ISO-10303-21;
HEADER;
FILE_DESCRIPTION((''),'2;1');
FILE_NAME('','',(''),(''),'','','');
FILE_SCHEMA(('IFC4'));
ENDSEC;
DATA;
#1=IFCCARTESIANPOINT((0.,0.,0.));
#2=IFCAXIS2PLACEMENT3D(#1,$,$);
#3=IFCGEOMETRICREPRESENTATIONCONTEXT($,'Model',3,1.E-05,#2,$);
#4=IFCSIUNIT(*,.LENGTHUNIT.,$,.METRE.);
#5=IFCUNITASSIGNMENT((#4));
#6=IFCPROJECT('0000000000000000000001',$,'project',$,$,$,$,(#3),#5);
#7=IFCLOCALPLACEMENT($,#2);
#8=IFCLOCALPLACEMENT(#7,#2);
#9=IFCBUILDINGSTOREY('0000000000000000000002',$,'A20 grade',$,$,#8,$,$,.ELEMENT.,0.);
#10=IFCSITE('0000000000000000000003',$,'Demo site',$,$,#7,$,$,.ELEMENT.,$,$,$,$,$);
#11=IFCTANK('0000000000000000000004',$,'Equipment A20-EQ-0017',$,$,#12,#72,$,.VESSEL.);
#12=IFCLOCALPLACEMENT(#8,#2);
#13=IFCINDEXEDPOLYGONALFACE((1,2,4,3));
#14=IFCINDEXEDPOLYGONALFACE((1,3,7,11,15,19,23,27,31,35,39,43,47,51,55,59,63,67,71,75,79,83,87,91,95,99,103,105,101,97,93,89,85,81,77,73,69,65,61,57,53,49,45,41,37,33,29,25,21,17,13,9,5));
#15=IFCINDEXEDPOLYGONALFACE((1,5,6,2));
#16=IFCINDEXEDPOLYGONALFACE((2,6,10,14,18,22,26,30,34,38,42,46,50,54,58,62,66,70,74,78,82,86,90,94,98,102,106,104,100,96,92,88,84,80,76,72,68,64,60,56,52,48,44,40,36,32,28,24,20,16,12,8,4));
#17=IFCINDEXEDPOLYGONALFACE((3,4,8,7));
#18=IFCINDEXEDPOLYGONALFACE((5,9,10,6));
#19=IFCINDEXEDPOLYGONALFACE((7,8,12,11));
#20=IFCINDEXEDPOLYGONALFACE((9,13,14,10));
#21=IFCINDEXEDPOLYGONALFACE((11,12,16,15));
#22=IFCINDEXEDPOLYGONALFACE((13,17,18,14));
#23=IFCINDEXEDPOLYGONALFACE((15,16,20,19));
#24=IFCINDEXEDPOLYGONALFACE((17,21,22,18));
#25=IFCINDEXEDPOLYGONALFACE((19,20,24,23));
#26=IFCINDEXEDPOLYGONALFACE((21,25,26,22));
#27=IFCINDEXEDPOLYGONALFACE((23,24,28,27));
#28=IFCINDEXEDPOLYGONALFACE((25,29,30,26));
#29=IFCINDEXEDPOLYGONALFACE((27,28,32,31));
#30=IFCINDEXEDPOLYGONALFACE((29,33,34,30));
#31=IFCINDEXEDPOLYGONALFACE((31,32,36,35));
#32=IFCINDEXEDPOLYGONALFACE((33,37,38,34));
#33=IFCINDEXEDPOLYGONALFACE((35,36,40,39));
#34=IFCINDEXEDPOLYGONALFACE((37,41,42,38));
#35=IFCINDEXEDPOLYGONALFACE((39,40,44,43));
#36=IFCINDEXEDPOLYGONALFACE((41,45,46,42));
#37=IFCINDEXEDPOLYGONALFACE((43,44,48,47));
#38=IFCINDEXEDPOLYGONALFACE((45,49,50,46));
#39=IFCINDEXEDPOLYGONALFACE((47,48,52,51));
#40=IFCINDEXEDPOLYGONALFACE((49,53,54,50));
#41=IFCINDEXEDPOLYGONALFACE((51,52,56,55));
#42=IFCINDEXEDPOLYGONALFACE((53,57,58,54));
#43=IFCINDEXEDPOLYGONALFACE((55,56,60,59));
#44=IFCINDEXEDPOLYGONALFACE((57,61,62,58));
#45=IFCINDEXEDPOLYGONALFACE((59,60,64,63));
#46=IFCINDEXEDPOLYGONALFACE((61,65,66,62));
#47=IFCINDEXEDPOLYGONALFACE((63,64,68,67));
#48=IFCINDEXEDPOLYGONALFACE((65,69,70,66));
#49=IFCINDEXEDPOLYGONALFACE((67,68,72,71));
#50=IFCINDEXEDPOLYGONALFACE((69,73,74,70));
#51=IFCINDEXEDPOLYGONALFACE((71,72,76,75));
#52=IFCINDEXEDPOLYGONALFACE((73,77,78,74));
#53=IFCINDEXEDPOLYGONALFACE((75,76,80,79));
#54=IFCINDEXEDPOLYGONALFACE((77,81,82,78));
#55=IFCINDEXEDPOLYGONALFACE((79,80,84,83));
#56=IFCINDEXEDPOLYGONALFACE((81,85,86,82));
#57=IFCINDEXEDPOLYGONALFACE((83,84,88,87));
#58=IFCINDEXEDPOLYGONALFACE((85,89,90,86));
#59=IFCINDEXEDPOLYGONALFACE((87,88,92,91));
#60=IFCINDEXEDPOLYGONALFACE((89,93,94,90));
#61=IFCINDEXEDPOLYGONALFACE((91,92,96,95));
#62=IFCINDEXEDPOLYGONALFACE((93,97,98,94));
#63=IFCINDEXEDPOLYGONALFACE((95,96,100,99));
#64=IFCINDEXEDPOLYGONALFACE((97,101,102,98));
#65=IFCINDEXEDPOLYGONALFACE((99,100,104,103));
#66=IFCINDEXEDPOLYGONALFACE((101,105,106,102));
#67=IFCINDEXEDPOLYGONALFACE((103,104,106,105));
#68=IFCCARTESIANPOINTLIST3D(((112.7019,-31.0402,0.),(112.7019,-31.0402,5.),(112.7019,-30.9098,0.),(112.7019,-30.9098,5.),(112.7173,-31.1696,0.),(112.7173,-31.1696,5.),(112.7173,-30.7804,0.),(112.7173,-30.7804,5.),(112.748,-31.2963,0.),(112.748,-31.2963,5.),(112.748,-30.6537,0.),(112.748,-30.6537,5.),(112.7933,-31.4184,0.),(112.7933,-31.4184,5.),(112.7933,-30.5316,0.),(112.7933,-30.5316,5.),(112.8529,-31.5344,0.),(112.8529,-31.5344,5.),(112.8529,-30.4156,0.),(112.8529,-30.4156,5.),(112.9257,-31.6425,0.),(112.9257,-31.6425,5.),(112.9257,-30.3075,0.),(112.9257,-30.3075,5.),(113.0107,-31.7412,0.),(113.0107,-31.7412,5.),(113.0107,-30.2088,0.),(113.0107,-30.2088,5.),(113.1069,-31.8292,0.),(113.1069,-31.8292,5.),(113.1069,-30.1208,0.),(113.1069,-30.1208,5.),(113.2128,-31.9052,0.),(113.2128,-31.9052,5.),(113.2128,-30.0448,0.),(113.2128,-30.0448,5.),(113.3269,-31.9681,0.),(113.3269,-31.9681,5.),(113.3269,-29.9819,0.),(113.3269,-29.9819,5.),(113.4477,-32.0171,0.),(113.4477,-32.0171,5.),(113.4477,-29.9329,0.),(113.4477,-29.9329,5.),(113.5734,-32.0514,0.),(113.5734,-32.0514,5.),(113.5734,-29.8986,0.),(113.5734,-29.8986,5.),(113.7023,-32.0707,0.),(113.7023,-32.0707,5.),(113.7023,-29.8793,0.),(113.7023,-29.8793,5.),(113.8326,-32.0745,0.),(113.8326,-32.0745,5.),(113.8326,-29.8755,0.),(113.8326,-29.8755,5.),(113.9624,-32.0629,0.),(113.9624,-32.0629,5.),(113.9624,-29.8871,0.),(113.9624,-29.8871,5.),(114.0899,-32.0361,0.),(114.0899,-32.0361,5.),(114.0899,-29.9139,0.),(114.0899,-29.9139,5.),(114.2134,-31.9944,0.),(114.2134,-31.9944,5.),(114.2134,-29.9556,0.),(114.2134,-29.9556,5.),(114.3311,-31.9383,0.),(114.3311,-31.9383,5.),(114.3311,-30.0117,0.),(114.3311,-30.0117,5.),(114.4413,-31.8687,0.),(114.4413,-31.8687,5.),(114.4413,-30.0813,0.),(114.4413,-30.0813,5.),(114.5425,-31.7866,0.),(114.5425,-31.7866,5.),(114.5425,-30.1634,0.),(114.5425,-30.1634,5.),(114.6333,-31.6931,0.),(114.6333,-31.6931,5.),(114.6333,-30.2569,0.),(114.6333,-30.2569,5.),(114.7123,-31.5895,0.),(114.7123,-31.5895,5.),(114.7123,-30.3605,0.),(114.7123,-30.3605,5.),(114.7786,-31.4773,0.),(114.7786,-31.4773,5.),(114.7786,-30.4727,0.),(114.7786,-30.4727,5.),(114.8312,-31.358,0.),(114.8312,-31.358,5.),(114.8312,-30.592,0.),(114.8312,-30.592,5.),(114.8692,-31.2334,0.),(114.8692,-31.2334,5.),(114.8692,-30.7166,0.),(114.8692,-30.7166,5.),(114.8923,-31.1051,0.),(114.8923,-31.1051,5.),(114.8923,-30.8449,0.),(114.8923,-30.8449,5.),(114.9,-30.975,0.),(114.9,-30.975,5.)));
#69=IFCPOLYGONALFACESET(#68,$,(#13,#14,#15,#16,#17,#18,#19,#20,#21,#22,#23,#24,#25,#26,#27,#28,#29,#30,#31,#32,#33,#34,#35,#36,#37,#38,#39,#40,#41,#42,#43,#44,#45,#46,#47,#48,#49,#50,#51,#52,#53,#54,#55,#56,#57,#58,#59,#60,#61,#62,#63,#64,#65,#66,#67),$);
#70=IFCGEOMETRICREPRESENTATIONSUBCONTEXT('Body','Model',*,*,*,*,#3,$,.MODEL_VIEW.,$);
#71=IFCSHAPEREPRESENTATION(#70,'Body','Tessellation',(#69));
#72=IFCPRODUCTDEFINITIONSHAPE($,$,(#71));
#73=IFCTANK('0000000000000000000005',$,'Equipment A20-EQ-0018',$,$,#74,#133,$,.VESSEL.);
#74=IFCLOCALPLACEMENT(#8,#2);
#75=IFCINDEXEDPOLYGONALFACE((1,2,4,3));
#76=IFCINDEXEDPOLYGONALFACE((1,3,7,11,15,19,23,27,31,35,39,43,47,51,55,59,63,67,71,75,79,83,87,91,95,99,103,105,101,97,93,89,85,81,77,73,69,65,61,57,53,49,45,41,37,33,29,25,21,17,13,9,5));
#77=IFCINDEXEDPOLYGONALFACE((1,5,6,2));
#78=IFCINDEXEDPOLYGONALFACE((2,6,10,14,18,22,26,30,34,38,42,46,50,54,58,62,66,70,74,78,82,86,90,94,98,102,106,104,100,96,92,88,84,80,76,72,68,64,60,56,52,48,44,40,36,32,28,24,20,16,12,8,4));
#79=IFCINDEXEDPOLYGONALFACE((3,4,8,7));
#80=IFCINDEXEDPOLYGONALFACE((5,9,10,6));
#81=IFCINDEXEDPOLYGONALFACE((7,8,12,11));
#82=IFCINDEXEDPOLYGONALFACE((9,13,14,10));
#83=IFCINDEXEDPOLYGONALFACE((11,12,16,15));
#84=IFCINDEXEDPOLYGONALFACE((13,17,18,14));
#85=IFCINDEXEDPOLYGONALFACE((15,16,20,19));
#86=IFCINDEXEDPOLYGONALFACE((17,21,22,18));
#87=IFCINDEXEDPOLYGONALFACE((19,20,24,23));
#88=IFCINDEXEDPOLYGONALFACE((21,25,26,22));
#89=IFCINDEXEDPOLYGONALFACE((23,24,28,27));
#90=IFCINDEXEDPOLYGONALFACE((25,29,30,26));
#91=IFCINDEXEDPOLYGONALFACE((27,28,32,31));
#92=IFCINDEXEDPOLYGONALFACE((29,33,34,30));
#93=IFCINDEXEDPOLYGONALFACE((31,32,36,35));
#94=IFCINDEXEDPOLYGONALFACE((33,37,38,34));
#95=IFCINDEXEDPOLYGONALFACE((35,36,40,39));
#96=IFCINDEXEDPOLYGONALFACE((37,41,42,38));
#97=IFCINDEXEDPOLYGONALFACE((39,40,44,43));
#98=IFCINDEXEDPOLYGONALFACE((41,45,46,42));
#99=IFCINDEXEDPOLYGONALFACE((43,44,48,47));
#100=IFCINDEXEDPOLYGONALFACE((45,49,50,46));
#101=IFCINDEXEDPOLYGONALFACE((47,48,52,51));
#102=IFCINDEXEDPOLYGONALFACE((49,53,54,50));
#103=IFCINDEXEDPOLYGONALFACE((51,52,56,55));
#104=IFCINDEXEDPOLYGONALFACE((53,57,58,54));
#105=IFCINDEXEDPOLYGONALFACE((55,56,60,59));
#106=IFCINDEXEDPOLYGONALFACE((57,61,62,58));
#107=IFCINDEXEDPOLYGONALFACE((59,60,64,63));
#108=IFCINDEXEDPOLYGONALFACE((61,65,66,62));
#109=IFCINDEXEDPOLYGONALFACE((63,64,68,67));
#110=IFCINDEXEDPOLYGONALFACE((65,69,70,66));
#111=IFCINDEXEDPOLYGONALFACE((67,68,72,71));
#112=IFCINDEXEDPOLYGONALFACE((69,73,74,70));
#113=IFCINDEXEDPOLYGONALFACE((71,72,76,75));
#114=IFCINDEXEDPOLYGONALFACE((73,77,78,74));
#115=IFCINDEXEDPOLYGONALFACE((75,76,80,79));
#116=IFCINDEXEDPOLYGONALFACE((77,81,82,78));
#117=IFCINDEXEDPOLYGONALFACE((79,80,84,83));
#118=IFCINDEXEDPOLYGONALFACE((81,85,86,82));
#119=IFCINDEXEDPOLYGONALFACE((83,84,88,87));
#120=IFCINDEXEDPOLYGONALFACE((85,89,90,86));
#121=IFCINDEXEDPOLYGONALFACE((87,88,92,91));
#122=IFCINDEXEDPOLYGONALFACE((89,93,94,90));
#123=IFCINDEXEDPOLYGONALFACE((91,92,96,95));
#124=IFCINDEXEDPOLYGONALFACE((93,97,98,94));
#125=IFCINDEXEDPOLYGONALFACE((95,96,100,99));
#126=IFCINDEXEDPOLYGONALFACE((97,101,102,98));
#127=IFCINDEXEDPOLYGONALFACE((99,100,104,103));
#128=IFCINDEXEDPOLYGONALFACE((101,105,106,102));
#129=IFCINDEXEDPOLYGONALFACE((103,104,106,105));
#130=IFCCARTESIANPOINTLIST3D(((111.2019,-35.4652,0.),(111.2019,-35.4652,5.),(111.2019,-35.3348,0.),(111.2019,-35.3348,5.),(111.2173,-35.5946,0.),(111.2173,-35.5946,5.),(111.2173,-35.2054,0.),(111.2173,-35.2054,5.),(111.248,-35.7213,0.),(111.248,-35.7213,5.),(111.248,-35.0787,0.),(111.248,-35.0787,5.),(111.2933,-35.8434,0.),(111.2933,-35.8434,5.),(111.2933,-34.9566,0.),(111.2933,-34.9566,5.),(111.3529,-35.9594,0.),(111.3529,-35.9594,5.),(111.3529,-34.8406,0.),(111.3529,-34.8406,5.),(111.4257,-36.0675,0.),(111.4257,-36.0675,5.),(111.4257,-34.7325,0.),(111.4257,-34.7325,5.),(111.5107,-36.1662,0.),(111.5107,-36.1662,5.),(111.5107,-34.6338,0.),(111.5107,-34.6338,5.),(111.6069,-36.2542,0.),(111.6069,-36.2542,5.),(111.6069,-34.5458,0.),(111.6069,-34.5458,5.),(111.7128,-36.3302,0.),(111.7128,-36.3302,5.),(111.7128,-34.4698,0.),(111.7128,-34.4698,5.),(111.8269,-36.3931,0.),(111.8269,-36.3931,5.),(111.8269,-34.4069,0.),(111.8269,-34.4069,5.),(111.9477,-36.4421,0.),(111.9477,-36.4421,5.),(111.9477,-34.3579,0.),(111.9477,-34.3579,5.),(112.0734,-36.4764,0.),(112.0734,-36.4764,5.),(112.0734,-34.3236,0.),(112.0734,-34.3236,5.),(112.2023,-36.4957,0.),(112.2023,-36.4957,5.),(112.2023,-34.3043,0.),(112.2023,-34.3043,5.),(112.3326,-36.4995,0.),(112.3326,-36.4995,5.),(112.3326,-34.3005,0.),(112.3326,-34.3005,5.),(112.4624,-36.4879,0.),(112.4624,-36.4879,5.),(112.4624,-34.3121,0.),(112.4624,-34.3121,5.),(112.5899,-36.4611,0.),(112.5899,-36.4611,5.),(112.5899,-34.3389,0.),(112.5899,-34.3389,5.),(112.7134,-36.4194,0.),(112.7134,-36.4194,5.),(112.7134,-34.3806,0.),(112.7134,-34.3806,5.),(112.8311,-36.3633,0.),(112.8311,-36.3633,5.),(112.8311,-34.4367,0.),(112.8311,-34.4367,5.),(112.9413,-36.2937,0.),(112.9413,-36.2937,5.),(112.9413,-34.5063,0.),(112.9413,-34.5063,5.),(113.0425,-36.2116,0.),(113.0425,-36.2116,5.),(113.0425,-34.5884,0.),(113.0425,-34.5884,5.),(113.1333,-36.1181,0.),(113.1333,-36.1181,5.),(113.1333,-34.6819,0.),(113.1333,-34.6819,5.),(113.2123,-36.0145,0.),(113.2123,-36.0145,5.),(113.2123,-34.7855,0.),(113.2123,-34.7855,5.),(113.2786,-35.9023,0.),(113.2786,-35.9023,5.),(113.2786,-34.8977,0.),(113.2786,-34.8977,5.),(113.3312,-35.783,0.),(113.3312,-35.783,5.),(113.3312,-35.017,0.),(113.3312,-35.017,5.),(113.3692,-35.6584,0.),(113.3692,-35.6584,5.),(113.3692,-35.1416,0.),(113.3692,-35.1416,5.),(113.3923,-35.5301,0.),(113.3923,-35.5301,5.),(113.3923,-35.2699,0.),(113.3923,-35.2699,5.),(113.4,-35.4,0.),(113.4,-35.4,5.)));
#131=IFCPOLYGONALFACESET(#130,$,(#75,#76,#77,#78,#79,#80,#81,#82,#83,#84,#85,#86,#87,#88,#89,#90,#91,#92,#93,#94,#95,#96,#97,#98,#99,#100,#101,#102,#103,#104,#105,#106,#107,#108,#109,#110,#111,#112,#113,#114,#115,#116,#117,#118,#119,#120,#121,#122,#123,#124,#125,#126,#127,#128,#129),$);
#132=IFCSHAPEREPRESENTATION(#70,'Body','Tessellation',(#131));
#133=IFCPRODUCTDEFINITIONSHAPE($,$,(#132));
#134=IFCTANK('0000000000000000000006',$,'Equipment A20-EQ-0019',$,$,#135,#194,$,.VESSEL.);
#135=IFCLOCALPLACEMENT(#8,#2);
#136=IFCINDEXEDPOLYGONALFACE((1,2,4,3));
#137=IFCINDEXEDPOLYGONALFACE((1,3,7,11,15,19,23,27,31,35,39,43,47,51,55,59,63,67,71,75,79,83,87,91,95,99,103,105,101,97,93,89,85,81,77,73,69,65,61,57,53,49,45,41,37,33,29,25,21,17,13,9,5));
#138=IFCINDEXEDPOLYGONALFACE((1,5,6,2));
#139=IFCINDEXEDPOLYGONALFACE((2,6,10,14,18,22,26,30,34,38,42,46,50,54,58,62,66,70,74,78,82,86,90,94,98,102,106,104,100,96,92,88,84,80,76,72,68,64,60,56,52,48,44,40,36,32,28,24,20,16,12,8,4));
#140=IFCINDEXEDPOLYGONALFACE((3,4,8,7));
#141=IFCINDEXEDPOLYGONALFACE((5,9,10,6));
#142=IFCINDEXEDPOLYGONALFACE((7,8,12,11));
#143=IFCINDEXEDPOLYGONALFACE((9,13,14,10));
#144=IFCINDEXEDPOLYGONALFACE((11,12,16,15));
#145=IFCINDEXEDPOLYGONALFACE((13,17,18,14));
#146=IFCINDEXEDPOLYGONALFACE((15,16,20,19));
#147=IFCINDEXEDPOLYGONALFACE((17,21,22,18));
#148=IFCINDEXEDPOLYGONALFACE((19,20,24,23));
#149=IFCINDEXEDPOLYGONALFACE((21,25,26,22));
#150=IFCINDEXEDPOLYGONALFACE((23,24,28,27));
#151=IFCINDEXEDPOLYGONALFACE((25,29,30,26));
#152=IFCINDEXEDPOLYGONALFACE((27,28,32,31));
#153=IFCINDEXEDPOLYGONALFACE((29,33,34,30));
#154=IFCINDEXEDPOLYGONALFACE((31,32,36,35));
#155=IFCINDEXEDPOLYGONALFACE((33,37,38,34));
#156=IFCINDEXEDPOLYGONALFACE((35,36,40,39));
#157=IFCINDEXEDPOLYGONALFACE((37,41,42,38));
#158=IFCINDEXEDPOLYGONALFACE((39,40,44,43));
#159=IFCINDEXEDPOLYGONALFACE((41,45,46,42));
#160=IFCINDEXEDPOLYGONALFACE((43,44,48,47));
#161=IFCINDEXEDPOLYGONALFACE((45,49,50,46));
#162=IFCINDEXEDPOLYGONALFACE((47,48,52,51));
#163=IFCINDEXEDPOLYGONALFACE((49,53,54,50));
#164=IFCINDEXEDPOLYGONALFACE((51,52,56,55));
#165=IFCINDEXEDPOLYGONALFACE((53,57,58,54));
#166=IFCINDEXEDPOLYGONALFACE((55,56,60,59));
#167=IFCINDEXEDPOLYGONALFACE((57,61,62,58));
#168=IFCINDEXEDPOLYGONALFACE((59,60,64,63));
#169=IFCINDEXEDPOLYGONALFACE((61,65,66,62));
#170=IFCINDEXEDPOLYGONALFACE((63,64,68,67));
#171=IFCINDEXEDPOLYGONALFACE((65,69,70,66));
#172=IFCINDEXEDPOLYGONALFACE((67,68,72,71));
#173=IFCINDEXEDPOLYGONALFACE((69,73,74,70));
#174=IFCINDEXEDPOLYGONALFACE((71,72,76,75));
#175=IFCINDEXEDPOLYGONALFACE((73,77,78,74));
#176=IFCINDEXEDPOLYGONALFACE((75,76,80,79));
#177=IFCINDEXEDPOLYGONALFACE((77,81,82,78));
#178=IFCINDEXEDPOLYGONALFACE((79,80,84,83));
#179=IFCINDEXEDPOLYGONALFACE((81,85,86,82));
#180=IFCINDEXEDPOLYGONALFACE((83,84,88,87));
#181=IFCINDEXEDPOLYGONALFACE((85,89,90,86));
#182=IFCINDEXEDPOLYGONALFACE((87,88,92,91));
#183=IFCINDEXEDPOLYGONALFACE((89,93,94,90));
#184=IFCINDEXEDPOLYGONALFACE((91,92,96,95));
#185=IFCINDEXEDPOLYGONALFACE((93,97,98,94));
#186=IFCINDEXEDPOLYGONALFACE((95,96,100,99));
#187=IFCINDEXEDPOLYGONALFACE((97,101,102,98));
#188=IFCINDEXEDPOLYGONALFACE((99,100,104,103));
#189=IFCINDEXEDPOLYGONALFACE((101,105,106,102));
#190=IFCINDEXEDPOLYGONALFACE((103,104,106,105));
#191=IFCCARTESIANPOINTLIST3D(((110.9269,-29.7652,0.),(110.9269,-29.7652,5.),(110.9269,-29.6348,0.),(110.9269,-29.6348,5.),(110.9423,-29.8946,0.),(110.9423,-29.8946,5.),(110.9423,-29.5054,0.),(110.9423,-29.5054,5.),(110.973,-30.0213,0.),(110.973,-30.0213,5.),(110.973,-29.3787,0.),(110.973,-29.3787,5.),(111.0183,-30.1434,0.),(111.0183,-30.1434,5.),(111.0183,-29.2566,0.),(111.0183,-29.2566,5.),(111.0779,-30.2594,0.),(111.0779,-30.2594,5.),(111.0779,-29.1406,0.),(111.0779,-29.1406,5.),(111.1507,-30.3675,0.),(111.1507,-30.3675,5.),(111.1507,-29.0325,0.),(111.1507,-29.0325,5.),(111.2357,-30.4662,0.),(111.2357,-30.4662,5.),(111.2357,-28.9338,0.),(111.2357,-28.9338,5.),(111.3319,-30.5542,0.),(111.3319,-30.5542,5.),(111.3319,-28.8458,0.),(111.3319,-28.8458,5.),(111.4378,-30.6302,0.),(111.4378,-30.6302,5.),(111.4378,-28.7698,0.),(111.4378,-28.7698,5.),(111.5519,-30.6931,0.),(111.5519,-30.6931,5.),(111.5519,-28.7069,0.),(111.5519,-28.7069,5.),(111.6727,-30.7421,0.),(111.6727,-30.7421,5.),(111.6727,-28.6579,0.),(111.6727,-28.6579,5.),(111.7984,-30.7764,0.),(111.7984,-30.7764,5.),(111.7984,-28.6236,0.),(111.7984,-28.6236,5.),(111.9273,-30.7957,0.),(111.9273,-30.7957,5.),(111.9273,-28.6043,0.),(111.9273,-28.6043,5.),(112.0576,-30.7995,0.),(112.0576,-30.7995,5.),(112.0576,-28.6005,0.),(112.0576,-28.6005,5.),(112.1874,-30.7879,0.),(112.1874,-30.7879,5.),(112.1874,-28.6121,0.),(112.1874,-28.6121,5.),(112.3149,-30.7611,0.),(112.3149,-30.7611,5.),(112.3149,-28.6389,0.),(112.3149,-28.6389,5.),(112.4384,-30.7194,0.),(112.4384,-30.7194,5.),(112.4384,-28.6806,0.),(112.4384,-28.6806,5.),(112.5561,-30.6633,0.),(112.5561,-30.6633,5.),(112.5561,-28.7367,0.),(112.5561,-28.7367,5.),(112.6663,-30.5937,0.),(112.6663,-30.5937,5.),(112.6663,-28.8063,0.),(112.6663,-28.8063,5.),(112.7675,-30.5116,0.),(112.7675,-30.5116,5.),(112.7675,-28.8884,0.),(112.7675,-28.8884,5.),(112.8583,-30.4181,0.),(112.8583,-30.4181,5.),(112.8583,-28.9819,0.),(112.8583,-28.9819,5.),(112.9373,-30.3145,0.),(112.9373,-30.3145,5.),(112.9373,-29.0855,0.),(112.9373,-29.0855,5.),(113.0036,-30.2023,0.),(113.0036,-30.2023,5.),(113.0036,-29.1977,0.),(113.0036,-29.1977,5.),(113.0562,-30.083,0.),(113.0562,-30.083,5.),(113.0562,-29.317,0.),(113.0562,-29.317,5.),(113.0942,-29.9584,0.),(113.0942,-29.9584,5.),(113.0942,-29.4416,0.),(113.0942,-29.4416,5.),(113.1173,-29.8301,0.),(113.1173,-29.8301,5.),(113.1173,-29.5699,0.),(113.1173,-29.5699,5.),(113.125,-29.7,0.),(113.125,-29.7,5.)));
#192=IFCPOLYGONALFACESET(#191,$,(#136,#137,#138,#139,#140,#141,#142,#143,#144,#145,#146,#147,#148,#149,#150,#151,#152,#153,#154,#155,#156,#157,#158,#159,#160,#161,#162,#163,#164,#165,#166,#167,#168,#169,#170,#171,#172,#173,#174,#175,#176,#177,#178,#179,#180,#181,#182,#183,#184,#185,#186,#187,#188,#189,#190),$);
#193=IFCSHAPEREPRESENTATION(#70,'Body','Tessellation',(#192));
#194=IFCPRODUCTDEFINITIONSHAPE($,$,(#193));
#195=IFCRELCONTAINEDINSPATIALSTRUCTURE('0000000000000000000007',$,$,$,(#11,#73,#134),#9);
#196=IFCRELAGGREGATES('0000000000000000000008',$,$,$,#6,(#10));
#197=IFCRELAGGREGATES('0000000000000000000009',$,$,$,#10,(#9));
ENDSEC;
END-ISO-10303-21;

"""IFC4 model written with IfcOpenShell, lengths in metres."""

from ifc_helpers import new_model, si_unit, frame, origin, place, context, subcontext, project, spatial, circle, extrude, element, save


model = new_model("IFC4")

# Units and contexts
model_context = context("Model", 3, precision=1e-05, world=origin())
body_context = subcontext(model_context, "Body", "Model", "MODEL_VIEW")
ifc_project = project(units=[si_unit("LENGTHUNIT", "METRE")], contexts=[model_context])

# Site, storey
site_placement = place(None, origin())
site = spatial("IfcSite", under=ifc_project, at=site_placement, Name="Demo site", CompositionType="ELEMENT")
storey_placement = place(site_placement, origin())
storey = spatial("IfcBuildingStorey", under=site, at=storey_placement, Name="A20 grade", CompositionType="ELEMENT", Elevation=0.0)

# Tanks
for number, where, name in (
    (1, (113.8, -30.975, 0.0), "Equipment A20-EQ-0017"),
    (2, (112.3, -35.4, 0.0), "Equipment A20-EQ-0018"),
    (3, (112.025, -29.7, 0.0), "Equipment A20-EQ-0019"),
):
    element("IfcTank", number, at=place(storey_placement, frame(where)), inside=storey, Name=name, PredefinedType="VESSEL", context=body_context, shape_type="SweptSolid", body=[
        extrude(circle(Radius=1.1), origin(), (0.0, 0.0, 1.0), 5.0),
    ])

save(model, "model.ifc")
